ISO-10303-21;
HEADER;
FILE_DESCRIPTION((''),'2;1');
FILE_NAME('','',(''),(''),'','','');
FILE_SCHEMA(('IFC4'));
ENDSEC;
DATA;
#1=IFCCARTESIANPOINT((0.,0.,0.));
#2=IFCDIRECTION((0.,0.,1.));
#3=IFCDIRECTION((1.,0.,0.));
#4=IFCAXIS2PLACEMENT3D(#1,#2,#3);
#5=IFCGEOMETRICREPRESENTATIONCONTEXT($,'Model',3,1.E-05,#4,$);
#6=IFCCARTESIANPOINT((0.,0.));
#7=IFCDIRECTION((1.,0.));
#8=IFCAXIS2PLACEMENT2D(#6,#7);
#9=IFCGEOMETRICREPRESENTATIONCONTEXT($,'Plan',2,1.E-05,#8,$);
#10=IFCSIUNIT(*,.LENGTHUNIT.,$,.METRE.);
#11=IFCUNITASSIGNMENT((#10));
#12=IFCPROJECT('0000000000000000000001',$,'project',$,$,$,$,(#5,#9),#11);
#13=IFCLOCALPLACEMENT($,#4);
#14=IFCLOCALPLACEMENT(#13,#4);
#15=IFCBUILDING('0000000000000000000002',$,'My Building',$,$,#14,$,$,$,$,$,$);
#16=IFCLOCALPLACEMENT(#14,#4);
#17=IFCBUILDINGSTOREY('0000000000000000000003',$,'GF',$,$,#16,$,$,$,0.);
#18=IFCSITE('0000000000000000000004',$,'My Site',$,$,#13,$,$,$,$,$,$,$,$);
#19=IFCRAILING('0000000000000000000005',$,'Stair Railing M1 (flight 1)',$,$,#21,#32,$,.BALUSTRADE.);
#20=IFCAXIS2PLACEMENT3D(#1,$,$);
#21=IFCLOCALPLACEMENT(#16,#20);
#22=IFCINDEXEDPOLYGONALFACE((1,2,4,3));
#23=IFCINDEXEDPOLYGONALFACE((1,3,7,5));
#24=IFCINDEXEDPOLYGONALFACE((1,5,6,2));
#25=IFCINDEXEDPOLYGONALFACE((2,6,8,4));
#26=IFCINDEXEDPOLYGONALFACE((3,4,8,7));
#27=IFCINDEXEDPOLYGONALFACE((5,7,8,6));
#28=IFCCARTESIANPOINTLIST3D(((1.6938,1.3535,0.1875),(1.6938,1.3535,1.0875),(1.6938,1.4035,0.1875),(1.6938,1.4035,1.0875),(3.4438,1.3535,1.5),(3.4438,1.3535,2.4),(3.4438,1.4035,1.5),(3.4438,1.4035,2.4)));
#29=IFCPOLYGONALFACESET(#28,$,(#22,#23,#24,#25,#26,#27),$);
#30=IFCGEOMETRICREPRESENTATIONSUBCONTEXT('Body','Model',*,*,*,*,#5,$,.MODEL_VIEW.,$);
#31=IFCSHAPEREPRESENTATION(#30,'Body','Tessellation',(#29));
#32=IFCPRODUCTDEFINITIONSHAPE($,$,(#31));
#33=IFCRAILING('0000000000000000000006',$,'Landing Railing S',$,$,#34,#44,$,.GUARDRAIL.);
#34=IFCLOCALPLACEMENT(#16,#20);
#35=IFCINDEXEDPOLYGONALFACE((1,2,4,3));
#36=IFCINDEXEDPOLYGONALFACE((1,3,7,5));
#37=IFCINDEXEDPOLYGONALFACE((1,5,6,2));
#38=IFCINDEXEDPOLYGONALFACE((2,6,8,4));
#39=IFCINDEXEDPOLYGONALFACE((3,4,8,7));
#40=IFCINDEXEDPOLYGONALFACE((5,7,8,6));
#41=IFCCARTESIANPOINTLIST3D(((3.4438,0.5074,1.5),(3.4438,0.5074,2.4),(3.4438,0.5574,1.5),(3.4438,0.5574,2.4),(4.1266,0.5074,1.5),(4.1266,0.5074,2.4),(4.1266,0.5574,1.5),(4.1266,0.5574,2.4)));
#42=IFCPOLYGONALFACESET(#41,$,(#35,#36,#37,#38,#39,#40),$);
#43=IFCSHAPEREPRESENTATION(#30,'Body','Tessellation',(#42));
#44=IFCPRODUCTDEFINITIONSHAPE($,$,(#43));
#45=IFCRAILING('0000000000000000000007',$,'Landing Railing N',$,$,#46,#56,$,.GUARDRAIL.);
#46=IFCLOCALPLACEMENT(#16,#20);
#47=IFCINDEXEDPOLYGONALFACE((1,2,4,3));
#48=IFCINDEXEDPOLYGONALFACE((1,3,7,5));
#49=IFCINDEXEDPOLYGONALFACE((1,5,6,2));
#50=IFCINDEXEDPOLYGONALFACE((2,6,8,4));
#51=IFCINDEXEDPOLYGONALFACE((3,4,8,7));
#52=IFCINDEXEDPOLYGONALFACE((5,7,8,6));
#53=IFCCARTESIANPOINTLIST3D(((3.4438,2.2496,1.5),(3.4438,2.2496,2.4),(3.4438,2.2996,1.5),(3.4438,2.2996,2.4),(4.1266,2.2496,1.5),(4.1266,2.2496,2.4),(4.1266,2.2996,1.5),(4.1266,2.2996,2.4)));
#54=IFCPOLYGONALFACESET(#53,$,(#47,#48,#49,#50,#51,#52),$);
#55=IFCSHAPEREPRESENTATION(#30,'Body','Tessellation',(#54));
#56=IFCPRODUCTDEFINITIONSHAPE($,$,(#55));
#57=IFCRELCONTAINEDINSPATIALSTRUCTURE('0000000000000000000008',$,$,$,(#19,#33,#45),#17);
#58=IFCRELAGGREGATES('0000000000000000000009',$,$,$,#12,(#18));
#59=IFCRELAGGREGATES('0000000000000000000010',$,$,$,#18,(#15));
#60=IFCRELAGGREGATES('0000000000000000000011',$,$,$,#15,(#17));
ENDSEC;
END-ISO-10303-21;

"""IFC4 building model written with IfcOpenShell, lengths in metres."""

from ifc_helpers import new_model, si_unit, frame, origin_with_axes, origin_2d_with_axis, place, context, subcontext, project, spatial, polyline, outline, extrude, element, save


model = new_model("IFC4")

# Units and contexts
model_context = context("Model", 3, precision=1e-05, world=origin_with_axes())
plan_context = context("Plan", 2, precision=1e-05, world=origin_2d_with_axis())
body_context_1 = subcontext(model_context, "Body", "Model", "MODEL_VIEW")
ifc_project = project(units=[si_unit("LENGTHUNIT", "METRE")], contexts=[model_context, plan_context])

# Site, building, storey
site_placement = place(None, origin_with_axes())
site = spatial("IfcSite", under=ifc_project, at=site_placement, Name="My Site")
building_placement = place(site_placement, origin_with_axes())
building = spatial("IfcBuilding", under=site, at=building_placement, Name="My Building")
storey_placement = place(building_placement, origin_with_axes())
storey = spatial("IfcBuildingStorey", under=building, at=storey_placement, Name="GF", Elevation=0.0)

# Railings
for number, where, z_axis, x_axis, name in (
    (1, (1.6938, 1.4035, 0.0), (0.0, -1.0, 0.0), (1.0, 0.0, 0.0), "Stair Railing M1 (flight 1)"),
):
    element("IfcRailing", number, at=place(storey_placement, frame(where, z_axis=z_axis, x_axis=x_axis)), inside=storey, Name=name, PredefinedType="BALUSTRADE", context=body_context_1, shape_type="SweptSolid", body=[
        extrude(outline(polyline([(0.0, 0.1875), (1.75, 1.5), (1.75, 2.4), (0.0, 1.0875), (0.0, 0.1875)])), origin_with_axes(), (0.0, 0.0, 1.0), 0.05),
    ])
railing_1_placement = place(storey_placement, frame((3.4438, 0.5574, 1.5), z_axis=(0.0, -1.0, 0.0), x_axis=(1.0, 0.0, 0.0)))
element("IfcRailing", 2, at=railing_1_placement, inside=storey, Name="Landing Railing S", PredefinedType="GUARDRAIL", context=body_context_1, shape_type="SweptSolid", body=[
    extrude(outline(polyline([(0.0, 0.0), (0.6829, 0.0), (0.6829, 0.9), (0.0, 0.9), (0.0, 0.0)])), origin_with_axes(), (0.0, 0.0, 1.0), 0.05),
])
railing_2_placement = place(storey_placement, frame((3.4438, 2.2996, 1.5), z_axis=(0.0, -1.0, 0.0), x_axis=(1.0, 0.0, 0.0)))
element("IfcRailing", 3, at=railing_2_placement, inside=storey, Name="Landing Railing N", PredefinedType="GUARDRAIL", context=body_context_1, shape_type="SweptSolid", body=[
    extrude(outline(polyline([(0.0, 0.0), (0.6829, 0.0), (0.6829, 0.9), (0.0, 0.9), (0.0, 0.0)])), origin_with_axes(), (0.0, 0.0, 1.0), 0.05),
])

save(model, "model.ifc")
